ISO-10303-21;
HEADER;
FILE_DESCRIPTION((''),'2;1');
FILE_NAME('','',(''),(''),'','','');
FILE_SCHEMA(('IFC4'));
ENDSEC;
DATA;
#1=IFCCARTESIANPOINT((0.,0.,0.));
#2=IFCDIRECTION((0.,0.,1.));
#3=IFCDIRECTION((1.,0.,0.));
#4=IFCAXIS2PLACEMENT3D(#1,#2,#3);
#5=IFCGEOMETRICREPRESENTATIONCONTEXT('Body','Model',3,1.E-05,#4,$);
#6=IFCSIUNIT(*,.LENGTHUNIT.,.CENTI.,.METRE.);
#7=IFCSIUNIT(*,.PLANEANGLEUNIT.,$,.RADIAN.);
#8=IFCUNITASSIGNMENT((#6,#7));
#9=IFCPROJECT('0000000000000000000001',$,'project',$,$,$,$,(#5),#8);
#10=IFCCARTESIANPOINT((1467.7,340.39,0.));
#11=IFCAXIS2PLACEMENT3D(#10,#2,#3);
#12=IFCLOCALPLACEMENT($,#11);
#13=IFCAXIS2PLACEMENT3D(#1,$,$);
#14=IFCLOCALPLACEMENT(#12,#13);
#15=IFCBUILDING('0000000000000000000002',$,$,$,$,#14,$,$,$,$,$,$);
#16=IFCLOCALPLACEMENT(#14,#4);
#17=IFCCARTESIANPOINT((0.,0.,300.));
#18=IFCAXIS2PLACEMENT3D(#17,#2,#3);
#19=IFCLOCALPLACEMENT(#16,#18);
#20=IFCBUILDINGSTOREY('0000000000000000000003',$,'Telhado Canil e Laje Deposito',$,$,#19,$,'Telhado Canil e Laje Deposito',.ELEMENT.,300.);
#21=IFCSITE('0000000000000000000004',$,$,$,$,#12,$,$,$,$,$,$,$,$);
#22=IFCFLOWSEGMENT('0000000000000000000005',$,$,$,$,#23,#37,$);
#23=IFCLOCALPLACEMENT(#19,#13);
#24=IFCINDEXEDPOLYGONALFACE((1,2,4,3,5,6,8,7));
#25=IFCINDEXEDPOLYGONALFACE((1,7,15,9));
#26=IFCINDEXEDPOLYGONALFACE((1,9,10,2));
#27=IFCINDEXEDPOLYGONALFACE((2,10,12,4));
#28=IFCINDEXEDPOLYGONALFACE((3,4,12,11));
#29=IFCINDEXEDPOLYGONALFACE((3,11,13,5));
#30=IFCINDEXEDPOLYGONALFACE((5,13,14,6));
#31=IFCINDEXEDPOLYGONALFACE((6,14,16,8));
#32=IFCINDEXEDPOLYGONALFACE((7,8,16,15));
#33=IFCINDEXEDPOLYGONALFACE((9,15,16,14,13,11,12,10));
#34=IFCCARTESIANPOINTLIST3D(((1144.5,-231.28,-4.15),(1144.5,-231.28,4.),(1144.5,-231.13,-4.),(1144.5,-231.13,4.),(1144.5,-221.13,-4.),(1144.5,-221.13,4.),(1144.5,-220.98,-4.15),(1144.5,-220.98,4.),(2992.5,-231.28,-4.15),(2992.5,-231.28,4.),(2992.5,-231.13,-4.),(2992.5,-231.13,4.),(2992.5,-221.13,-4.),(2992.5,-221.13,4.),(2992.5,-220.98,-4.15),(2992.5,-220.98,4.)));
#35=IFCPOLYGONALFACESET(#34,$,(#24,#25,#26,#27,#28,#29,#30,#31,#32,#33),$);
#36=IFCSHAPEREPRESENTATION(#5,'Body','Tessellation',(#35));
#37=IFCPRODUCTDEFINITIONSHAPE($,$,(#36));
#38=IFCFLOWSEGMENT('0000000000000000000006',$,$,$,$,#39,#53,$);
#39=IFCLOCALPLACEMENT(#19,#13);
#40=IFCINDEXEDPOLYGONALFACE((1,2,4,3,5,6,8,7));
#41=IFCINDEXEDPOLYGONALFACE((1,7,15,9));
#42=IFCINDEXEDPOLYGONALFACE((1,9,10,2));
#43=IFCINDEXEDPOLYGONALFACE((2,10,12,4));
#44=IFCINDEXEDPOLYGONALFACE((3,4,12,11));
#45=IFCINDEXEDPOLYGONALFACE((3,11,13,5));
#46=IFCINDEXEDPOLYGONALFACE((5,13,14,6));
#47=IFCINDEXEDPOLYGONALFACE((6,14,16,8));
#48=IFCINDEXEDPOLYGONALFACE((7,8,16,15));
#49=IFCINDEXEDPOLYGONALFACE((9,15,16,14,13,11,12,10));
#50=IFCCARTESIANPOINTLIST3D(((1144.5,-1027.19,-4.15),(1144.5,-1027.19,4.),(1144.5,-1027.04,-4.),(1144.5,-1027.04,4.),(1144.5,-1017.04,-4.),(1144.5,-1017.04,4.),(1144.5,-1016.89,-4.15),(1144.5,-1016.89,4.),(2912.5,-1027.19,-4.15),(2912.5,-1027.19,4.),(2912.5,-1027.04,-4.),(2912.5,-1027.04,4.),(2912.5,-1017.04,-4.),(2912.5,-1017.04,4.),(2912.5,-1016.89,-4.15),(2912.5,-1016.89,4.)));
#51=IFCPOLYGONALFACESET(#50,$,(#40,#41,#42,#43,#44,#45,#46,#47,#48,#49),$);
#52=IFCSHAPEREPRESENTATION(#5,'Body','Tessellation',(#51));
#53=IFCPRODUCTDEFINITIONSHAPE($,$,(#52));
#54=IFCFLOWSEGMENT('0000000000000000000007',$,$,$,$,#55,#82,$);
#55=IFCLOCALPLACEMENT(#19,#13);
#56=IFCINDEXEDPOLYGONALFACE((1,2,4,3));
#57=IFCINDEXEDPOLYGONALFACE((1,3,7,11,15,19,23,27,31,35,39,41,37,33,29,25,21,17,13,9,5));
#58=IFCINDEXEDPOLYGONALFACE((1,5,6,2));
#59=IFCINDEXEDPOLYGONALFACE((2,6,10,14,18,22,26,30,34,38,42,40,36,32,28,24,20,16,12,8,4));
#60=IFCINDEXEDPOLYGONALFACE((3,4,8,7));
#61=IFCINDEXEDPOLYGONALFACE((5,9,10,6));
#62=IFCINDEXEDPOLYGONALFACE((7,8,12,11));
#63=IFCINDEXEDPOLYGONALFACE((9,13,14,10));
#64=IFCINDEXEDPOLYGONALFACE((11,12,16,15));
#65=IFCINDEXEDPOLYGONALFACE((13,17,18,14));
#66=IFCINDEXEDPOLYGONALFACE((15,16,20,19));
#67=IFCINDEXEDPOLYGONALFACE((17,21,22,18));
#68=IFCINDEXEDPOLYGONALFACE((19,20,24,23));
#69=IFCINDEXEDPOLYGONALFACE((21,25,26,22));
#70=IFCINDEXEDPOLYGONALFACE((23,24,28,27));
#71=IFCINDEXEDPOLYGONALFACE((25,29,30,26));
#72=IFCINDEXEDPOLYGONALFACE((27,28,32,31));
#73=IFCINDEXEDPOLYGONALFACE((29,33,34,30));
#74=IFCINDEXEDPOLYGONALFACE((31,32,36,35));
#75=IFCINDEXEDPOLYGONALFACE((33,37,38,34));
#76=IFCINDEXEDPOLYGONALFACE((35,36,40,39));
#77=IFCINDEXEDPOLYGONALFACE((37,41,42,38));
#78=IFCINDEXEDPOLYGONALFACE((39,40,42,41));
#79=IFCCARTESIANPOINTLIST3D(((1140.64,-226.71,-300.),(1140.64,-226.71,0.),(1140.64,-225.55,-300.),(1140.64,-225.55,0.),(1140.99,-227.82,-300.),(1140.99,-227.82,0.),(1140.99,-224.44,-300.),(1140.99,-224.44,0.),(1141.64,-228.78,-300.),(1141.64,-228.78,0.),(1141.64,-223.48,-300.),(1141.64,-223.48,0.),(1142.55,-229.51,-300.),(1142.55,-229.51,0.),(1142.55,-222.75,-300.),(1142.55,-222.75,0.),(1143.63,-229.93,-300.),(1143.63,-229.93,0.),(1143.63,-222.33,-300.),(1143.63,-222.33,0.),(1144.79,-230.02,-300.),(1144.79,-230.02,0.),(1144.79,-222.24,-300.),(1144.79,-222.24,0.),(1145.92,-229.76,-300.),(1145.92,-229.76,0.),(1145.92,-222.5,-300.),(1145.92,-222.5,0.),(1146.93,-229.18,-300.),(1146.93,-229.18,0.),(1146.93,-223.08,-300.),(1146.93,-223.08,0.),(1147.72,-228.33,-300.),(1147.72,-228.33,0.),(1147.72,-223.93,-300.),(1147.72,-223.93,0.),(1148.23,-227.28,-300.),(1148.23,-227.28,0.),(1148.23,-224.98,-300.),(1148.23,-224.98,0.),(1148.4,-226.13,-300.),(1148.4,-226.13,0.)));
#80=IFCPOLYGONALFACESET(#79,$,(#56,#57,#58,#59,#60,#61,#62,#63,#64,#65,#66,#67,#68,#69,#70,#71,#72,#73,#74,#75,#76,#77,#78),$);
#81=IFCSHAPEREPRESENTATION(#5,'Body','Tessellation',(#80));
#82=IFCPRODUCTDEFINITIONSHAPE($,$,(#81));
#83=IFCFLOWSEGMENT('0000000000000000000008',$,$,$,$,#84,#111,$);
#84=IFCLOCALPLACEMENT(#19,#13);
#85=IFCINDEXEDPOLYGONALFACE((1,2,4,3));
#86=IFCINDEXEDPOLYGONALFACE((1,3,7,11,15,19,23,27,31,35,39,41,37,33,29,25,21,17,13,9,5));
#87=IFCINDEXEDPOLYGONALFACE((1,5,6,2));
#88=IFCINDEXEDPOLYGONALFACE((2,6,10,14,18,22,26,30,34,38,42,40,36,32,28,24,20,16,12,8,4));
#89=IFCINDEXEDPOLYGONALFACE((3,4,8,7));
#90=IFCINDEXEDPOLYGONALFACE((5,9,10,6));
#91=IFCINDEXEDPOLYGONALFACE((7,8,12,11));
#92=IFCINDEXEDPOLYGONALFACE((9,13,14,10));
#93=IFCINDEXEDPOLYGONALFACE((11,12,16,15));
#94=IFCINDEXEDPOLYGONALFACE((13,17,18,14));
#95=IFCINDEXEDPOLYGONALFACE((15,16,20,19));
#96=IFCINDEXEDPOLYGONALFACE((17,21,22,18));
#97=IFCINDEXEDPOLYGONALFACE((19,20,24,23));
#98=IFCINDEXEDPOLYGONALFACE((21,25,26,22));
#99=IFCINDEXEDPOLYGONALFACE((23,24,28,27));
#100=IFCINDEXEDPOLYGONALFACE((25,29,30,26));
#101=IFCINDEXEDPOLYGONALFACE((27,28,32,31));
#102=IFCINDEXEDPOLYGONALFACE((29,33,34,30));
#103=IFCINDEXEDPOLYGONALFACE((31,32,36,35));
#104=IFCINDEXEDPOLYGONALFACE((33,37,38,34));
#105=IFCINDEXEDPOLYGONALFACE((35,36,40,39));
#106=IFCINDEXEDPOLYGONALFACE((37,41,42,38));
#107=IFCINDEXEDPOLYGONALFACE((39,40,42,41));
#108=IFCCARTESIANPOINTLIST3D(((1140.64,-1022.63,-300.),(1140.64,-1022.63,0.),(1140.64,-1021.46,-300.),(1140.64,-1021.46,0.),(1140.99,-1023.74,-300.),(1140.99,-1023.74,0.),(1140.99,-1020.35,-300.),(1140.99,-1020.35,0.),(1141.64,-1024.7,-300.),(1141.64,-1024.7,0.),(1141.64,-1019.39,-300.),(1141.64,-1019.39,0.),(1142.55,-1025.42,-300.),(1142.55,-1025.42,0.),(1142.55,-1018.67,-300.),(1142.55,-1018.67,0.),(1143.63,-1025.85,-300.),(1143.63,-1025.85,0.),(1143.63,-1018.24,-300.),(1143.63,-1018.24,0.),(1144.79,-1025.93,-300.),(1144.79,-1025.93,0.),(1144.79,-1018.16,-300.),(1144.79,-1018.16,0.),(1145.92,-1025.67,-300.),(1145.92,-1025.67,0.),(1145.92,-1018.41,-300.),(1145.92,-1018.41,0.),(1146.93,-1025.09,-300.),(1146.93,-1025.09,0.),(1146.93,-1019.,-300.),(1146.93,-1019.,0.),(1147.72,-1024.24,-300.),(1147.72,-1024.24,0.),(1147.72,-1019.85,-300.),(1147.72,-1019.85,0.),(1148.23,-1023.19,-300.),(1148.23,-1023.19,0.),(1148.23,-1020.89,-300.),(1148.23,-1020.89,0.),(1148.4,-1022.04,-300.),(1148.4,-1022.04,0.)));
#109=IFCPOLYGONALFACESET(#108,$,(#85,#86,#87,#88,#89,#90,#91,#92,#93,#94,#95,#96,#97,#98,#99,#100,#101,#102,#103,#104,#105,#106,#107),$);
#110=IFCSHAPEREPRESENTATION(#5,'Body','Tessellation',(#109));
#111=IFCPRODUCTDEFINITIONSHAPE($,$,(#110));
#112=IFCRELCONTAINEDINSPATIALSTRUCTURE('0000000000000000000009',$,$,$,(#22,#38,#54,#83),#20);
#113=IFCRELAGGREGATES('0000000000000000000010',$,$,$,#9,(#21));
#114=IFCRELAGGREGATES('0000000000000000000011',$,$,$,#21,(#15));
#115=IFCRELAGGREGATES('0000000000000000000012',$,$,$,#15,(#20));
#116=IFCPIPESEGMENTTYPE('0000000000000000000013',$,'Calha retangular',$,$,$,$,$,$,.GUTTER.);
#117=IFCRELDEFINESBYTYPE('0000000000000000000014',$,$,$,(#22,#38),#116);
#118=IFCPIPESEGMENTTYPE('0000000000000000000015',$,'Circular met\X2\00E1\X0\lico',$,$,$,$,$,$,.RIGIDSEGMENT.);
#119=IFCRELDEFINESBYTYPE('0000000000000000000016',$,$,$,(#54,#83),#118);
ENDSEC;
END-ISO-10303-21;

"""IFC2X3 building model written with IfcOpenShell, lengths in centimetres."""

from ifc_helpers import new_model, si_unit, frame, origin, origin_with_axes, origin_2d_with_axis, place, context, project, spatial, polyline, circle, outline, extrude, type_object, element, save


model = new_model("IFC2X3")

# Units and contexts
model_context = context("Model", 3, precision=1e-05, world=origin_with_axes(), identifier="Body")
ifc_project = project(units=[si_unit("LENGTHUNIT", "METRE", prefix="CENTI"), si_unit("PLANEANGLEUNIT", "RADIAN")], contexts=[model_context])

# Site, building, storey
site_placement = place(None, frame((1467.7, 340.39, 0.0), z_axis=(0.0, 0.0, 1.0), x_axis=(1.0, 0.0, 0.0)))
site = spatial("IfcSite", under=ifc_project, at=site_placement)
building_placement = place(site_placement, origin())
building = spatial("IfcBuilding", under=site, at=building_placement)
placement = place(building_placement, origin_with_axes())
storey_placement = place(placement, frame((0.0, 0.0, 300.0), z_axis=(0.0, 0.0, 1.0), x_axis=(1.0, 0.0, 0.0)))
storey = spatial("IfcBuildingStorey", under=building, at=storey_placement, Name="Telhado Canil e Laje Deposito", LongName="Telhado Canil e Laje Deposito", CompositionType="ELEMENT", Elevation=300.0)

# Flow segments
pipe_segment_type_1 = type_object("IfcPipeSegmentType", Name="Calha retangular", PredefinedType="GUTTER")
flow_segment_1_placement = place(storey_placement, frame((2068.5, -226.13, 4.0), z_axis=(0.0, 0.0, 1.0), x_axis=(1.0, 0.0, 0.0)))
element("IfcFlowSegment", 1, at=flow_segment_1_placement, inside=storey, type_object=pipe_segment_type_1, context=model_context, shape_type="SolidModel", body=[
    extrude(outline(polyline([(0.0, 0.0), (8.0, 0.0), (8.0, 0.15), (-0.15, 0.15), (-0.15, -10.15), (8.0, -10.15), (8.0, -10.0), (0.0, -10.0), (0.0, 0.0)])), frame((924.0, 5.0, -8.0), z_axis=(-1.0, 0.0, 0.0), x_axis=(0.0, 0.0, 1.0)), (0.0, 0.0, 1.0), 1848.0),
])
flow_segment_2_placement = place(storey_placement, frame((2028.5, -1022.04, 4.0), z_axis=(0.0, 0.0, 1.0), x_axis=(1.0, 0.0, 0.0)))
element("IfcFlowSegment", 2, at=flow_segment_2_placement, inside=storey, type_object=pipe_segment_type_1, context=model_context, shape_type="SolidModel", body=[
    extrude(outline(polyline([(0.0, 0.0), (8.0, 0.0), (8.0, 0.15), (-0.15, 0.15), (-0.15, -10.15), (8.0, -10.15), (8.0, -10.0), (0.0, -10.0), (0.0, 0.0)])), frame((884.0, 5.0, -8.0), z_axis=(-1.0, 0.0, 0.0), x_axis=(0.0, 0.0, 1.0)), (0.0, 0.0, 1.0), 1768.0),
])
pipe_segment_type_2 = type_object("IfcPipeSegmentType", Name="Circular metálico", PredefinedType="RIGIDSEGMENT")
for number, where, z_axis, x_axis in (
    (3, (1144.5, -226.13, 0.0), (0.0, 0.0, 1.0), (1.0, 0.0, 0.0)),
    (4, (1144.5, -1022.04, 0.0), (0.0, 0.0, 1.0), (1.0, 0.0, 0.0)),
):
    element("IfcFlowSegment", number, at=place(storey_placement, frame(where, z_axis=z_axis, x_axis=x_axis)), inside=storey, type_object=pipe_segment_type_2, context=model_context, shape_type="SolidModel", body=[
        extrude(circle(Radius=3.9, at=origin_2d_with_axis()), frame((0.0, 0.0, 0.0), z_axis=(0.0, 0.0, -1.0), x_axis=(1.0, 0.0, 0.0)), (0.0, 0.0, 1.0), 300.0),
    ])

save(model, "model.ifc")
